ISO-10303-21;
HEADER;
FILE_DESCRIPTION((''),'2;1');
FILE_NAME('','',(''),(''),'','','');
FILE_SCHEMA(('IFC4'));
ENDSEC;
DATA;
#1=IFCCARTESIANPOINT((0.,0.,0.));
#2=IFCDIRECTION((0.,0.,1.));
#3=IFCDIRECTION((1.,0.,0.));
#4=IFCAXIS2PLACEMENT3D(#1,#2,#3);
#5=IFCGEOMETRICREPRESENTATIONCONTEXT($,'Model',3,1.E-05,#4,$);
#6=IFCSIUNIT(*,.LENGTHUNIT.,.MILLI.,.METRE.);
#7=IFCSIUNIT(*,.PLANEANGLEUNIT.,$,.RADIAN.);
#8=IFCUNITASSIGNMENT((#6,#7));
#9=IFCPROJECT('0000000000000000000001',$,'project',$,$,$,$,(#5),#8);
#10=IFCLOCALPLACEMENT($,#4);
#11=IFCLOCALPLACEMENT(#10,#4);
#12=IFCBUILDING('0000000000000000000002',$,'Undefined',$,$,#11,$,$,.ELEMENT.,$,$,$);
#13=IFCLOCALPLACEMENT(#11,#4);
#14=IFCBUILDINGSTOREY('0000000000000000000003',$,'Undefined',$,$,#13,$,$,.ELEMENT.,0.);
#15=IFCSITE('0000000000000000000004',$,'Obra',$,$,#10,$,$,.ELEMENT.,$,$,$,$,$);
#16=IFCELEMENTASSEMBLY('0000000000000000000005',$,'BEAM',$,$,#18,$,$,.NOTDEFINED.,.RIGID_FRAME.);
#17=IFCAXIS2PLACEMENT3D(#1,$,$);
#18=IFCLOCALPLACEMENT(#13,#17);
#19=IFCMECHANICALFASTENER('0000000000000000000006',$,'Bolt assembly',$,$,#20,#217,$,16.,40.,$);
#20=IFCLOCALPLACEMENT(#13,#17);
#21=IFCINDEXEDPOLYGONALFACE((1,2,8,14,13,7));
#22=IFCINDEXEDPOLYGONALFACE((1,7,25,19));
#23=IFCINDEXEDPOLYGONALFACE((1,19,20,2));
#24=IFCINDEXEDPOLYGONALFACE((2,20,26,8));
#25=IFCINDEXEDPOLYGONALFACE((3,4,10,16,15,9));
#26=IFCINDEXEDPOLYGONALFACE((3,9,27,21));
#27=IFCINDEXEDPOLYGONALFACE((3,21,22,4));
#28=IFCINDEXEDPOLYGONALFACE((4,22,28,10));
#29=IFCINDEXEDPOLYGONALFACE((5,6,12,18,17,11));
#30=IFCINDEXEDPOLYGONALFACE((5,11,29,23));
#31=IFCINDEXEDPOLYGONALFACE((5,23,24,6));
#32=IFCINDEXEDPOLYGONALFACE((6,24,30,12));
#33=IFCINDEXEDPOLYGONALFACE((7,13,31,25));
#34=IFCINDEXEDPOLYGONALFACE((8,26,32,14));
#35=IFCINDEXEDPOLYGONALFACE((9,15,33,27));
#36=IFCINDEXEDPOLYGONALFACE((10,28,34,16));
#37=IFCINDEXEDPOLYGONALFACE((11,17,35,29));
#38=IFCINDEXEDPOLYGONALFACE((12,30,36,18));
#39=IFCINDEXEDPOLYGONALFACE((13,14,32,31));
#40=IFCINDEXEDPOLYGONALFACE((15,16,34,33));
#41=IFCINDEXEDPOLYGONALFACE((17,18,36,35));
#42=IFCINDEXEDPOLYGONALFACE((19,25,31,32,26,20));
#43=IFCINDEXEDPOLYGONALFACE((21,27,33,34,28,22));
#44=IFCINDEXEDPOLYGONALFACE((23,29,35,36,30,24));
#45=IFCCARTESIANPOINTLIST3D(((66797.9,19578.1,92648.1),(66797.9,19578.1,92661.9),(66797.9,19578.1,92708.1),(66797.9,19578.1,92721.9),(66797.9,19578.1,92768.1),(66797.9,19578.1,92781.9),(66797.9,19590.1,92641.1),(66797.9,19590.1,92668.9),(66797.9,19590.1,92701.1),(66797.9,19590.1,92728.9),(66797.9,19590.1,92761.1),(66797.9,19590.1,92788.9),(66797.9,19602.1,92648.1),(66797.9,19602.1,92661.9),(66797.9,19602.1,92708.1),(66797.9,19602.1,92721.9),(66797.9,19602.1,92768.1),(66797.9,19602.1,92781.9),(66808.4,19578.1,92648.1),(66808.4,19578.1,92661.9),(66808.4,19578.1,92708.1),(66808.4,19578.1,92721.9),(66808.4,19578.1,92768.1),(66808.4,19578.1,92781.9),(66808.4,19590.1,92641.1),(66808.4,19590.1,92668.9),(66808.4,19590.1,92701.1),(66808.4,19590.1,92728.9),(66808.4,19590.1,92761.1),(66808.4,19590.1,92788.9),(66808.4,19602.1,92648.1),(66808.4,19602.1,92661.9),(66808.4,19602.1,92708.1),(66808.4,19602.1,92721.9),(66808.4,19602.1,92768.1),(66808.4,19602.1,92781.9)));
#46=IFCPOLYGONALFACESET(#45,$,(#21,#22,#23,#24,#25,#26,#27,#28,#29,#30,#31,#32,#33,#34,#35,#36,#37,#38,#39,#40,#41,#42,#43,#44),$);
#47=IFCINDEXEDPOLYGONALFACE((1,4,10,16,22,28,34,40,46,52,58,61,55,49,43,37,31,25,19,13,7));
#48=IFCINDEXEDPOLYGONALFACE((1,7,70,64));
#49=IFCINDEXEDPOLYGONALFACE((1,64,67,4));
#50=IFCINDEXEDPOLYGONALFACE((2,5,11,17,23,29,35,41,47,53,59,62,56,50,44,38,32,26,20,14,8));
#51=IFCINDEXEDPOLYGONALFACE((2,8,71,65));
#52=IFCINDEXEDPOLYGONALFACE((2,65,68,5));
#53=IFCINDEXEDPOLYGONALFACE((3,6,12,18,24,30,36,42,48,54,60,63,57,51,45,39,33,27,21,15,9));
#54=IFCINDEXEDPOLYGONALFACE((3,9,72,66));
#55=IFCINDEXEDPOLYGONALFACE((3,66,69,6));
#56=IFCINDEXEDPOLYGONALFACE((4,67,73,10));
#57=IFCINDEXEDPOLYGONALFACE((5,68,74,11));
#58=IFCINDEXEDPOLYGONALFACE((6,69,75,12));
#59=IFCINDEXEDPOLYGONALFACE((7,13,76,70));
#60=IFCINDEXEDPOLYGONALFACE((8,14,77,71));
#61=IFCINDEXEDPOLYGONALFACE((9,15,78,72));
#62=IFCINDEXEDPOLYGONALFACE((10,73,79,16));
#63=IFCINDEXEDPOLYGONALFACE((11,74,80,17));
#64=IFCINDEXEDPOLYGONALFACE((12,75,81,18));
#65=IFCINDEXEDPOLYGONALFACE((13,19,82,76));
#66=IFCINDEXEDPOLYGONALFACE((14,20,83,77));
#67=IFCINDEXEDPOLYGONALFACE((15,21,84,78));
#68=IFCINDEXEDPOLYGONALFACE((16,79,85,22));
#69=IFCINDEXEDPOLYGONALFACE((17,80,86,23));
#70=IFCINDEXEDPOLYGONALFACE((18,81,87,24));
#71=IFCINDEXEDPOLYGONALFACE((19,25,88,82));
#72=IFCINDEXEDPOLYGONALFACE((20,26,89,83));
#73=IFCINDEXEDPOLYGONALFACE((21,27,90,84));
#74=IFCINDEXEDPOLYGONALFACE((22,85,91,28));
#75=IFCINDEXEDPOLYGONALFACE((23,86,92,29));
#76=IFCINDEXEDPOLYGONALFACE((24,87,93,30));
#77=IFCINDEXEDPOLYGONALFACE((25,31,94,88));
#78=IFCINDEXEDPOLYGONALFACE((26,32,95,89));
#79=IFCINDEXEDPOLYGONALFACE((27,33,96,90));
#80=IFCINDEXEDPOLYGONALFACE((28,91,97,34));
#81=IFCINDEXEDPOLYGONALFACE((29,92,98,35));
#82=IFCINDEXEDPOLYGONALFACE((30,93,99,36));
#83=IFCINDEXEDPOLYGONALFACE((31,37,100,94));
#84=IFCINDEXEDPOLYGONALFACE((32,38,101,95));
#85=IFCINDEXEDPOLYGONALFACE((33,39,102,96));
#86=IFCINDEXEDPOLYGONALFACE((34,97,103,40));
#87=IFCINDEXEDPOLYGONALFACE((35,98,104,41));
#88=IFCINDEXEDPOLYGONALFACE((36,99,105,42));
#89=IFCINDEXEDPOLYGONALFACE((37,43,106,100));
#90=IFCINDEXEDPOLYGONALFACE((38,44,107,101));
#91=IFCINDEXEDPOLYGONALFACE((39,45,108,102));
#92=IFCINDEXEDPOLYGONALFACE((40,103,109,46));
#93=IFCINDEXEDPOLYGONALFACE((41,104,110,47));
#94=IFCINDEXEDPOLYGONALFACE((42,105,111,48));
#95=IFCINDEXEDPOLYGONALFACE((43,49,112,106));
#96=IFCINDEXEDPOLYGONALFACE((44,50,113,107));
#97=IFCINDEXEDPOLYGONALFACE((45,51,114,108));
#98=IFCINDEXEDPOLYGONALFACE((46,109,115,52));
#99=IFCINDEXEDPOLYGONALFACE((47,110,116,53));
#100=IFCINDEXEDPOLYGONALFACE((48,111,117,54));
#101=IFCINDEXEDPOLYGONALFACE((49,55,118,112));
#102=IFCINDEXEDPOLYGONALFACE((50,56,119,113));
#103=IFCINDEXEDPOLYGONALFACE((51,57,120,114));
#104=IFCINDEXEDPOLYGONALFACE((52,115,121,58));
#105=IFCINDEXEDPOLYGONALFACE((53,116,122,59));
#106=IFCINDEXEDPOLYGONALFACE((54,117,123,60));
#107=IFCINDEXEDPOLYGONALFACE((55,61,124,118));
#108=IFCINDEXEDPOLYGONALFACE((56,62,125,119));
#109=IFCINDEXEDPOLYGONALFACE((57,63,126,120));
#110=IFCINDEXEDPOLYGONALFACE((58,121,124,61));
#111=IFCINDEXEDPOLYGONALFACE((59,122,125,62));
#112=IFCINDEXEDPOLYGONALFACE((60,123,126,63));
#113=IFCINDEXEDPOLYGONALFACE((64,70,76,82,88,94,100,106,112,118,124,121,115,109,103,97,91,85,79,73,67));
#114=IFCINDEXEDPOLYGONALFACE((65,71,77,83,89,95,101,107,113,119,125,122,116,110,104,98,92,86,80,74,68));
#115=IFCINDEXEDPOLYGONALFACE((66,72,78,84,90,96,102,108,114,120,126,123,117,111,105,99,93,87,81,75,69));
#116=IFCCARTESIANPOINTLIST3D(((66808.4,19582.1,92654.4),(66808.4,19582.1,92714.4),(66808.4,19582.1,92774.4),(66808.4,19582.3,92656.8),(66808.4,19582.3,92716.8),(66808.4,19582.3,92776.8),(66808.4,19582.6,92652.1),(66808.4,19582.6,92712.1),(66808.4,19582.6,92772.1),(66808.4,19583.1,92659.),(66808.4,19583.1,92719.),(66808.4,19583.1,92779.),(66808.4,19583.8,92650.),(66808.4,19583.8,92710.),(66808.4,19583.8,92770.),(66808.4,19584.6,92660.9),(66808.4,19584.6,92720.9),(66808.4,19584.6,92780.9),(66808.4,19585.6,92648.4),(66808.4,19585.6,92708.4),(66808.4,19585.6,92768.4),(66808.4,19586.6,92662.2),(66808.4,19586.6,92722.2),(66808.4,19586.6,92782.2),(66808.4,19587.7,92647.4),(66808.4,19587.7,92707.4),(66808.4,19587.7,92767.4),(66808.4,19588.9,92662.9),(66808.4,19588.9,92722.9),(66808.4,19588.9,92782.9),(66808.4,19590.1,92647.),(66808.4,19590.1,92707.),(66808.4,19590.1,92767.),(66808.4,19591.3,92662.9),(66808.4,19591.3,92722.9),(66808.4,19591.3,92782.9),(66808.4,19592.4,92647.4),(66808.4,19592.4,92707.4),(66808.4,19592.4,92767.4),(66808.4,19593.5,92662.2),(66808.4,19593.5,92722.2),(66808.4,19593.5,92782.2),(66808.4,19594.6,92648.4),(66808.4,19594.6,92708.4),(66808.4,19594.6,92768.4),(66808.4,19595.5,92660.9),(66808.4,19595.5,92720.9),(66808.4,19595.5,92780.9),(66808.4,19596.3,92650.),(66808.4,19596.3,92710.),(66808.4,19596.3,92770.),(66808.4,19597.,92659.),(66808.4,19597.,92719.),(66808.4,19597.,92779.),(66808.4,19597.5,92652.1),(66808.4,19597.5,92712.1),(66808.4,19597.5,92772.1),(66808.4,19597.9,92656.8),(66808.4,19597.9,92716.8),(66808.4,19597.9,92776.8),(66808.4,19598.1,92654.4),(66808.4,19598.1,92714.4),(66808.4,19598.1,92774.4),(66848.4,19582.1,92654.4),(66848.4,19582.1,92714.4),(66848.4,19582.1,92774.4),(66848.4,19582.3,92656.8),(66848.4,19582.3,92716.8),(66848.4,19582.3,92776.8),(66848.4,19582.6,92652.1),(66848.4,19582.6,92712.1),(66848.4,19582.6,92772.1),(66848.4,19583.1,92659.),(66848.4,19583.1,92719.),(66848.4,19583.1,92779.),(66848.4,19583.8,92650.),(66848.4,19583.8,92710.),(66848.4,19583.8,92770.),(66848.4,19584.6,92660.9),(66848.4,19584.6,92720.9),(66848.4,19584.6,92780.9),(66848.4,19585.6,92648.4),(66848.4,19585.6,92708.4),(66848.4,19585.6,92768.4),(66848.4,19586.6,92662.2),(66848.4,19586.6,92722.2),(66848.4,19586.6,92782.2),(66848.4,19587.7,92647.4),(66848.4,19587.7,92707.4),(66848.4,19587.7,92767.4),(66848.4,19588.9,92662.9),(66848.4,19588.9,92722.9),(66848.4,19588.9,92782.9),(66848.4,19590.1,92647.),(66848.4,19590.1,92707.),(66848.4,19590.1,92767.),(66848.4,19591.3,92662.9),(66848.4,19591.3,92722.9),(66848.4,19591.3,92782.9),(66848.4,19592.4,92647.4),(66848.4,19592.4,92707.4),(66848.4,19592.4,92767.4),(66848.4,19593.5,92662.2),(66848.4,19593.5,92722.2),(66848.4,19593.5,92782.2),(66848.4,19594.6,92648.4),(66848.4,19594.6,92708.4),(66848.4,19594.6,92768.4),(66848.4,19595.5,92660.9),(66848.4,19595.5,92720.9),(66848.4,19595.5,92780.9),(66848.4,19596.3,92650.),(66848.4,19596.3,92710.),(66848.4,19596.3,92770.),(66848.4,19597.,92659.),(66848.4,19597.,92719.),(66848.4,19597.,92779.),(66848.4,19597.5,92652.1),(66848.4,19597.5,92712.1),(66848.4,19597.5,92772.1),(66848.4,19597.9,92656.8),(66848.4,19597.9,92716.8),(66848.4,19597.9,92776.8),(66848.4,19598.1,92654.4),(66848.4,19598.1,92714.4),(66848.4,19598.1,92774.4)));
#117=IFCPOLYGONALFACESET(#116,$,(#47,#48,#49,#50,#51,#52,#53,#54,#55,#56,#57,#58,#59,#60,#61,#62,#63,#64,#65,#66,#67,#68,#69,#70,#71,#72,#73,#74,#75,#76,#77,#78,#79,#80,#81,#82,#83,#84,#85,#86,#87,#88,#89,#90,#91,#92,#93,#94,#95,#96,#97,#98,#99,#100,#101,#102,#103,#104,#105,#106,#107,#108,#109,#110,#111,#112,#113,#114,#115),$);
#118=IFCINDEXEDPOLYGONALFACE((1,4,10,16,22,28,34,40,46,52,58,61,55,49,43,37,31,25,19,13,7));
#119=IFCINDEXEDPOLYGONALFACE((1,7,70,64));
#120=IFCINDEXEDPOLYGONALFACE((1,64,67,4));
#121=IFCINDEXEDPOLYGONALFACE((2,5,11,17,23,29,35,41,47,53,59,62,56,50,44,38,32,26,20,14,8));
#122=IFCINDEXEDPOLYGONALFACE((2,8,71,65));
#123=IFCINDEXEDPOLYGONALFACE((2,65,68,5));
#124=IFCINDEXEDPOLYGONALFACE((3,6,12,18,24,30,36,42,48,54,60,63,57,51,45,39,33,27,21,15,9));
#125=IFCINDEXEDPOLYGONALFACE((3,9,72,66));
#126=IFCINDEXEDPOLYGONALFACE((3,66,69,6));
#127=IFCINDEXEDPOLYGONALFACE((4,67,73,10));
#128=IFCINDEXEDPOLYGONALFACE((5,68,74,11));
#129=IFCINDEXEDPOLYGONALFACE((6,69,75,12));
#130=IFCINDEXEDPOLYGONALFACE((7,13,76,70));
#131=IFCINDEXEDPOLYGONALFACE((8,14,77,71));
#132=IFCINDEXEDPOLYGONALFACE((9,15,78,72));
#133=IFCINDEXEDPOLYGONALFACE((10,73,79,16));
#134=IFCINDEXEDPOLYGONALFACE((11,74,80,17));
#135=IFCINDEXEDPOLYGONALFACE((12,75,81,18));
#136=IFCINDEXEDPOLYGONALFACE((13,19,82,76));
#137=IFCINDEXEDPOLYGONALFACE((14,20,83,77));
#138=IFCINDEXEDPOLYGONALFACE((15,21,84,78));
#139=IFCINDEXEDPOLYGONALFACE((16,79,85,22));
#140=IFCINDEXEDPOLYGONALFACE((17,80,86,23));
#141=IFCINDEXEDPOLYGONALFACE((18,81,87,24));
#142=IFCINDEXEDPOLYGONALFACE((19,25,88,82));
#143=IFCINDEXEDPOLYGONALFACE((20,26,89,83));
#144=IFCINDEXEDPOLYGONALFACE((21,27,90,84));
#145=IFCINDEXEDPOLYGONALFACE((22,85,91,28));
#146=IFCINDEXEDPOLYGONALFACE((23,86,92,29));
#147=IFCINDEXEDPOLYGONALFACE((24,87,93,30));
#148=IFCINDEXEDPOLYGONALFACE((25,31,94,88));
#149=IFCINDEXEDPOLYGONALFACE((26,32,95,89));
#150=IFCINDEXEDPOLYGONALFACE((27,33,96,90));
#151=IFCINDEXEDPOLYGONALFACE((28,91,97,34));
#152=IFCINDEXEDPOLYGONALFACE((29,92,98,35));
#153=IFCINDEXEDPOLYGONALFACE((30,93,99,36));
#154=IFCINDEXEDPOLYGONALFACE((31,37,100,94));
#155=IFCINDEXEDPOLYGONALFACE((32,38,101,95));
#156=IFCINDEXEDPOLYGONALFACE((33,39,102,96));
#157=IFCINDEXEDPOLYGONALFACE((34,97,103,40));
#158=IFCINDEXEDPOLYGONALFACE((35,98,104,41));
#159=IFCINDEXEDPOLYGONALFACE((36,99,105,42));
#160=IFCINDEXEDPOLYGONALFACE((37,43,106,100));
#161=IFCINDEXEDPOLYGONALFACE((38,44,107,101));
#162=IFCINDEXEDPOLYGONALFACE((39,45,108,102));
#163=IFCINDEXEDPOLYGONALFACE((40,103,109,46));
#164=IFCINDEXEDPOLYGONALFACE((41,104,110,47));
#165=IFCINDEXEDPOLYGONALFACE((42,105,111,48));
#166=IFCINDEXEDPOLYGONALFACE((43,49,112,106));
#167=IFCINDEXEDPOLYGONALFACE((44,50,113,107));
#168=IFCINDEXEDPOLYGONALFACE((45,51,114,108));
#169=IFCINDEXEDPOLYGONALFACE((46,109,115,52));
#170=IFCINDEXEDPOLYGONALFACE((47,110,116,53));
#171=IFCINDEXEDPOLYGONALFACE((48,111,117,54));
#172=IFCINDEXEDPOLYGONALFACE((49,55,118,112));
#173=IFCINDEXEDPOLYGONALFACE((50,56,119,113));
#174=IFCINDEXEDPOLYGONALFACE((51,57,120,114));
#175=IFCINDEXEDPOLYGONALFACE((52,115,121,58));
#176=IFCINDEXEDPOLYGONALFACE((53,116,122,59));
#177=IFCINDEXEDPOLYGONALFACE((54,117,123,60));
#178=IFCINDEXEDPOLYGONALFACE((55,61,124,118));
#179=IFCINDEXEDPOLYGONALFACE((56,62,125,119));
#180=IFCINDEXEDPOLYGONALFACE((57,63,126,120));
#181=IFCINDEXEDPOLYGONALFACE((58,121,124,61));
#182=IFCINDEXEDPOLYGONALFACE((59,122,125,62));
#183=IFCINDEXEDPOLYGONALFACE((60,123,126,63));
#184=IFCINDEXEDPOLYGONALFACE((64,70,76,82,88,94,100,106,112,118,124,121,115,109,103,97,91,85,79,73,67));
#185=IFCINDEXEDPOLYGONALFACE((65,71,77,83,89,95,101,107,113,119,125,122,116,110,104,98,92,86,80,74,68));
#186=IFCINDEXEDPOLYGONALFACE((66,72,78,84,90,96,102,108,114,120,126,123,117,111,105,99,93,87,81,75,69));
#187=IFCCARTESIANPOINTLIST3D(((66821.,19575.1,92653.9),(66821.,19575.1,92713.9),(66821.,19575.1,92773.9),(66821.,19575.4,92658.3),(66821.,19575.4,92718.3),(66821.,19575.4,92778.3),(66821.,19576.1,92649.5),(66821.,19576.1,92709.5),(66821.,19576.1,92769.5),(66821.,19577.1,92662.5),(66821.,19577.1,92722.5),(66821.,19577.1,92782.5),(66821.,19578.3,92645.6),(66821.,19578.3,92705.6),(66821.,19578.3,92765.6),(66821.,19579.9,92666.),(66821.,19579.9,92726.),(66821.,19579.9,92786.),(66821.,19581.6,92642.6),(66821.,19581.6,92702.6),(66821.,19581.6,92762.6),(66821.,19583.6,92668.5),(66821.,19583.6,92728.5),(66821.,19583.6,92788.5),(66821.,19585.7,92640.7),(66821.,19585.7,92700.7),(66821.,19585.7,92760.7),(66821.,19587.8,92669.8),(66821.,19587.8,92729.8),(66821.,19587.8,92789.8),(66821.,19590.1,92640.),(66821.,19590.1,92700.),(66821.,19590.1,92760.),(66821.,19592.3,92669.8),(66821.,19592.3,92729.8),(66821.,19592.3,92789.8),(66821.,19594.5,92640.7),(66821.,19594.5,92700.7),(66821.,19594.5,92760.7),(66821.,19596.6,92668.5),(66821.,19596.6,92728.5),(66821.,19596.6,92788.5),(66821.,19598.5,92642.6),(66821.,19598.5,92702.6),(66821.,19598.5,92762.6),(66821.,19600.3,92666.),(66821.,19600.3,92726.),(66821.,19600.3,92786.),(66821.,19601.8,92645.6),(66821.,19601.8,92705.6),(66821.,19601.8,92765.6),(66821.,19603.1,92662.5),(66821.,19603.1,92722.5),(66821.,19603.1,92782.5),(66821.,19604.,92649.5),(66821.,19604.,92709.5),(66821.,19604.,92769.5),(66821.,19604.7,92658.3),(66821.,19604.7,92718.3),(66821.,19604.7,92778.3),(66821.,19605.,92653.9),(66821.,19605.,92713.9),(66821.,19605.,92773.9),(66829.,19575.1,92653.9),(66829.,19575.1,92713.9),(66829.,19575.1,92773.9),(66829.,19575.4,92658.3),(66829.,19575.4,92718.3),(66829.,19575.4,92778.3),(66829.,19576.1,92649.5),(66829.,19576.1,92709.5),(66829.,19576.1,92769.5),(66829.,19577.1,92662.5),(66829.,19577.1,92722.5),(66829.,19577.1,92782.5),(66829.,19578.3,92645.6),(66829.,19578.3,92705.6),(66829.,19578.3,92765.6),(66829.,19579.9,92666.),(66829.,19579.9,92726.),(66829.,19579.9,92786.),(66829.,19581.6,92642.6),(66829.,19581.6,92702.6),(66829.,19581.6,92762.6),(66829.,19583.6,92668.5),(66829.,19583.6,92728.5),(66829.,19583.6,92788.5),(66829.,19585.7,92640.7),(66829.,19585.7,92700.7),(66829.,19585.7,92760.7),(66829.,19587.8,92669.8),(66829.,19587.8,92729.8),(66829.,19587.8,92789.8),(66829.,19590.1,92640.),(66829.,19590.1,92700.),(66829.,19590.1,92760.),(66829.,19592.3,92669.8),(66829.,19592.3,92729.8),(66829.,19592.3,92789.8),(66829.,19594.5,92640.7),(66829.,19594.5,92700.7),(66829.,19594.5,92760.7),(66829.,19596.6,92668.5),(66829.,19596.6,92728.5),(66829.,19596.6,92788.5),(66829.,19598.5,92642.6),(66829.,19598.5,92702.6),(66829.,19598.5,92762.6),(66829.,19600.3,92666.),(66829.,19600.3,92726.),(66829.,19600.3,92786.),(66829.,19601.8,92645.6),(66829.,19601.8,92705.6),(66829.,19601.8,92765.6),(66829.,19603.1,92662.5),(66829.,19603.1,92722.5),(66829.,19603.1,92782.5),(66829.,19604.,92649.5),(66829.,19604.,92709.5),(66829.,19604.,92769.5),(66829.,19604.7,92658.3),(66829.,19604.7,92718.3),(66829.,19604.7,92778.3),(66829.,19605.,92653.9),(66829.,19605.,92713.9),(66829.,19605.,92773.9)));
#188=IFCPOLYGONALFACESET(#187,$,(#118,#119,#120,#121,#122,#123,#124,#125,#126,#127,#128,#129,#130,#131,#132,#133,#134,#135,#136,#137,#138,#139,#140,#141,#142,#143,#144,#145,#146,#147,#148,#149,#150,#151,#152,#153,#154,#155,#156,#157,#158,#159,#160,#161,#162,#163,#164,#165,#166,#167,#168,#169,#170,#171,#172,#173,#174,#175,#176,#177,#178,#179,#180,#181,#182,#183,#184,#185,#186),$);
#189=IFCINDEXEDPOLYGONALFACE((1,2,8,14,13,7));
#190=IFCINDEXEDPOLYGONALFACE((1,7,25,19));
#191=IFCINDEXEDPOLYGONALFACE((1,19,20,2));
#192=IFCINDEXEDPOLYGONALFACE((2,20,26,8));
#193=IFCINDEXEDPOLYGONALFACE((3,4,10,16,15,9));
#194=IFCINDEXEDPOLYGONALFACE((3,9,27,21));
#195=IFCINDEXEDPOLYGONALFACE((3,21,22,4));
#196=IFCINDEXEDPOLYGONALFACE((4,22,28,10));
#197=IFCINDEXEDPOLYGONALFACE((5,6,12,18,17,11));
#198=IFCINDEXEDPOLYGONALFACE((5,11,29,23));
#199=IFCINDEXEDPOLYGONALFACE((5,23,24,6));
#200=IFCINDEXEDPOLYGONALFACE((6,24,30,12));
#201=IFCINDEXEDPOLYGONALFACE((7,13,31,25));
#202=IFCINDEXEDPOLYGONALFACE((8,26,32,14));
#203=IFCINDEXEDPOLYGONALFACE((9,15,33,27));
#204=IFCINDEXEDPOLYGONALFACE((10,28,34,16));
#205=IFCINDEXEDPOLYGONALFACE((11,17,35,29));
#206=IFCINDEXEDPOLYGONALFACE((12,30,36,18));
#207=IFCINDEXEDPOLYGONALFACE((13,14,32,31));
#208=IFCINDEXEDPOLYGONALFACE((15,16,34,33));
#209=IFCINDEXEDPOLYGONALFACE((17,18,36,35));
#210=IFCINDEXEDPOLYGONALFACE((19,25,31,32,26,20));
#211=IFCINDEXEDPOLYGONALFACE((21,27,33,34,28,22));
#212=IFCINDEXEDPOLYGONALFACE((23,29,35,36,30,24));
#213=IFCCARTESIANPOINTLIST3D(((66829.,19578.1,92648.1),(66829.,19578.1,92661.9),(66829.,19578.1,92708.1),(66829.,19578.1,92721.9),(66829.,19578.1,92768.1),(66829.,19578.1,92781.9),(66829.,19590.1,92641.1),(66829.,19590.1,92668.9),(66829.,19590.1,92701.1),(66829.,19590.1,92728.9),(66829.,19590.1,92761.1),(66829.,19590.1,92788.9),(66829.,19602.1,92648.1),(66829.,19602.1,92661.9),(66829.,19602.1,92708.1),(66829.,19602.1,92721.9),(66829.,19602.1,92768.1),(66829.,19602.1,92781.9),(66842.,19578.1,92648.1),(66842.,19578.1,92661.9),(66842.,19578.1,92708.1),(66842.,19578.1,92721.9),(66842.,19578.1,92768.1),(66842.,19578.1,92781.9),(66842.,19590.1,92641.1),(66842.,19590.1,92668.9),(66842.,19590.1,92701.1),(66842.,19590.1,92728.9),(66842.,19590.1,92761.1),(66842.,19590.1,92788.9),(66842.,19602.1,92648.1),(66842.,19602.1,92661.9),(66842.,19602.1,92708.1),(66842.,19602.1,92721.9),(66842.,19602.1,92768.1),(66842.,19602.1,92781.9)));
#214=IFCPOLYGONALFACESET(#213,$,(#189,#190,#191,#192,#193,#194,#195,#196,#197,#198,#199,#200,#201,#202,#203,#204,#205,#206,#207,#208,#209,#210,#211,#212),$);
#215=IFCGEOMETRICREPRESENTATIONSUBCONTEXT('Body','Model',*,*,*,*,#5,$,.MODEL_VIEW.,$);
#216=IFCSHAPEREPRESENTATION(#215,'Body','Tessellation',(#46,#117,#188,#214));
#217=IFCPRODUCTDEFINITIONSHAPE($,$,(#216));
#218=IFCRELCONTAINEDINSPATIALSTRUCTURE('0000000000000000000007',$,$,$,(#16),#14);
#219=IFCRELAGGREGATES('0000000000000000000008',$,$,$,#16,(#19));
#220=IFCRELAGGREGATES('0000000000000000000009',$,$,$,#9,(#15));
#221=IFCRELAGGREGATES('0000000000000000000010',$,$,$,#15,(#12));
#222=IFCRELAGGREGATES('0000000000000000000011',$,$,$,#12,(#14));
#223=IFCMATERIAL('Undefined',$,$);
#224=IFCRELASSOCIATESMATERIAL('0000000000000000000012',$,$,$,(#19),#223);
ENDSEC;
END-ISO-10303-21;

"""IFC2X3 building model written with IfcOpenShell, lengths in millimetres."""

from ifc_helpers import new_model, si_unit, frame, origin_with_axes, origin_2d_with_axis, place, context, subcontext, project, spatial, polyline, circle, outline, extrude, source, transform, mapped, material, element, aggregate, save


model = new_model("IFC2X3")

# Units and contexts
model_context = context("Model", 3, precision=1e-05, world=origin_with_axes())
body_context = subcontext(model_context, "Body", "Model", "MODEL_VIEW")
ifc_project = project(units=[si_unit("LENGTHUNIT", "METRE", prefix="MILLI"), si_unit("PLANEANGLEUNIT", "RADIAN")], contexts=[model_context])

# Site, building, storey
site_placement = place(None, origin_with_axes())
site = spatial("IfcSite", under=ifc_project, at=site_placement, Name="Obra", CompositionType="ELEMENT")
building_placement = place(site_placement, origin_with_axes())
building = spatial("IfcBuilding", under=site, at=building_placement, Name="Undefined", CompositionType="ELEMENT")
storey_placement = place(building_placement, origin_with_axes())
storey = spatial("IfcBuildingStorey", under=building, at=storey_placement, Name="Undefined", CompositionType="ELEMENT", Elevation=0.0)

# Element assembly, mechanical fastener
assembly_1_placement = place(storey_placement, origin_with_axes())
assembly_1 = element("IfcElementAssembly", 1, at=assembly_1_placement, inside=storey, Name="BEAM", AssemblyPlace="NOTDEFINED", PredefinedType="RIGID_FRAME")
ifc_material_1 = material(Name="Undefined")
shared_shape_1 = source(origin_with_axes(), body_context, "Body", "SweptSolid", [
    extrude(outline(polyline([(13.9, 0.0), (6.9, 12.0), (-6.9, 12.0), (-13.9, 0.0), (-6.9, -12.0), (6.9, -12.0), (13.9, 0.0)])), frame((0.0, -19.9, 0.0), z_axis=(0.0, 1.0, 0.0), x_axis=(1.0, 0.0, 0.0)), (0.0, 0.0, 1.0), 10.6),
    extrude(circle(Radius=8.0, at=origin_2d_with_axis()), frame((0.0, -9.3, 0.0), z_axis=(0.0, 1.0, 0.0), x_axis=(1.0, 0.0, 0.0)), (0.0, 0.0, 1.0), 40.0),
    extrude(circle(Radius=15.0, at=origin_2d_with_axis()), frame((0.0, 3.3, 0.0), z_axis=(0.0, 1.0, 0.0), x_axis=(1.0, 0.0, 0.0)), (0.0, 0.0, 1.0), 8.0),
    extrude(outline(polyline([(13.9, 0.0), (6.9, 12.0), (-6.9, 12.0), (-13.9, 0.0), (-6.9, -12.0), (6.9, -12.0), (13.9, 0.0)])), frame((0.0, 11.3, 0.0), z_axis=(0.0, 1.0, 0.0), x_axis=(1.0, 0.0, 0.0)), (0.0, 0.0, 1.0), 13.0),
])
mechanical_fastener_1_placement = place(assembly_1_placement, frame((66817.7, 19640.1, 92850.0), z_axis=(0.000002, -1.0, 0.0), x_axis=(0.0, 0.0, -1.0)))
mechanical_fastener_1 = element("IfcMechanicalFastener", 2, at=mechanical_fastener_1_placement, material=ifc_material_1, Name="Bolt assembly", NominalDiameter=16.0, NominalLength=40.0, context=body_context, shape_type="MappedRepresentation", body=[
    mapped(shared_shape_1, transform((75.0, 0.0, 50.0))),
    mapped(shared_shape_1, transform((135.0, 0.0, 50.0))),
    mapped(shared_shape_1, transform((195.0, 0.0, 50.0))),
])
aggregate(assembly_1, [mechanical_fastener_1])

save(model, "model.ifc")
